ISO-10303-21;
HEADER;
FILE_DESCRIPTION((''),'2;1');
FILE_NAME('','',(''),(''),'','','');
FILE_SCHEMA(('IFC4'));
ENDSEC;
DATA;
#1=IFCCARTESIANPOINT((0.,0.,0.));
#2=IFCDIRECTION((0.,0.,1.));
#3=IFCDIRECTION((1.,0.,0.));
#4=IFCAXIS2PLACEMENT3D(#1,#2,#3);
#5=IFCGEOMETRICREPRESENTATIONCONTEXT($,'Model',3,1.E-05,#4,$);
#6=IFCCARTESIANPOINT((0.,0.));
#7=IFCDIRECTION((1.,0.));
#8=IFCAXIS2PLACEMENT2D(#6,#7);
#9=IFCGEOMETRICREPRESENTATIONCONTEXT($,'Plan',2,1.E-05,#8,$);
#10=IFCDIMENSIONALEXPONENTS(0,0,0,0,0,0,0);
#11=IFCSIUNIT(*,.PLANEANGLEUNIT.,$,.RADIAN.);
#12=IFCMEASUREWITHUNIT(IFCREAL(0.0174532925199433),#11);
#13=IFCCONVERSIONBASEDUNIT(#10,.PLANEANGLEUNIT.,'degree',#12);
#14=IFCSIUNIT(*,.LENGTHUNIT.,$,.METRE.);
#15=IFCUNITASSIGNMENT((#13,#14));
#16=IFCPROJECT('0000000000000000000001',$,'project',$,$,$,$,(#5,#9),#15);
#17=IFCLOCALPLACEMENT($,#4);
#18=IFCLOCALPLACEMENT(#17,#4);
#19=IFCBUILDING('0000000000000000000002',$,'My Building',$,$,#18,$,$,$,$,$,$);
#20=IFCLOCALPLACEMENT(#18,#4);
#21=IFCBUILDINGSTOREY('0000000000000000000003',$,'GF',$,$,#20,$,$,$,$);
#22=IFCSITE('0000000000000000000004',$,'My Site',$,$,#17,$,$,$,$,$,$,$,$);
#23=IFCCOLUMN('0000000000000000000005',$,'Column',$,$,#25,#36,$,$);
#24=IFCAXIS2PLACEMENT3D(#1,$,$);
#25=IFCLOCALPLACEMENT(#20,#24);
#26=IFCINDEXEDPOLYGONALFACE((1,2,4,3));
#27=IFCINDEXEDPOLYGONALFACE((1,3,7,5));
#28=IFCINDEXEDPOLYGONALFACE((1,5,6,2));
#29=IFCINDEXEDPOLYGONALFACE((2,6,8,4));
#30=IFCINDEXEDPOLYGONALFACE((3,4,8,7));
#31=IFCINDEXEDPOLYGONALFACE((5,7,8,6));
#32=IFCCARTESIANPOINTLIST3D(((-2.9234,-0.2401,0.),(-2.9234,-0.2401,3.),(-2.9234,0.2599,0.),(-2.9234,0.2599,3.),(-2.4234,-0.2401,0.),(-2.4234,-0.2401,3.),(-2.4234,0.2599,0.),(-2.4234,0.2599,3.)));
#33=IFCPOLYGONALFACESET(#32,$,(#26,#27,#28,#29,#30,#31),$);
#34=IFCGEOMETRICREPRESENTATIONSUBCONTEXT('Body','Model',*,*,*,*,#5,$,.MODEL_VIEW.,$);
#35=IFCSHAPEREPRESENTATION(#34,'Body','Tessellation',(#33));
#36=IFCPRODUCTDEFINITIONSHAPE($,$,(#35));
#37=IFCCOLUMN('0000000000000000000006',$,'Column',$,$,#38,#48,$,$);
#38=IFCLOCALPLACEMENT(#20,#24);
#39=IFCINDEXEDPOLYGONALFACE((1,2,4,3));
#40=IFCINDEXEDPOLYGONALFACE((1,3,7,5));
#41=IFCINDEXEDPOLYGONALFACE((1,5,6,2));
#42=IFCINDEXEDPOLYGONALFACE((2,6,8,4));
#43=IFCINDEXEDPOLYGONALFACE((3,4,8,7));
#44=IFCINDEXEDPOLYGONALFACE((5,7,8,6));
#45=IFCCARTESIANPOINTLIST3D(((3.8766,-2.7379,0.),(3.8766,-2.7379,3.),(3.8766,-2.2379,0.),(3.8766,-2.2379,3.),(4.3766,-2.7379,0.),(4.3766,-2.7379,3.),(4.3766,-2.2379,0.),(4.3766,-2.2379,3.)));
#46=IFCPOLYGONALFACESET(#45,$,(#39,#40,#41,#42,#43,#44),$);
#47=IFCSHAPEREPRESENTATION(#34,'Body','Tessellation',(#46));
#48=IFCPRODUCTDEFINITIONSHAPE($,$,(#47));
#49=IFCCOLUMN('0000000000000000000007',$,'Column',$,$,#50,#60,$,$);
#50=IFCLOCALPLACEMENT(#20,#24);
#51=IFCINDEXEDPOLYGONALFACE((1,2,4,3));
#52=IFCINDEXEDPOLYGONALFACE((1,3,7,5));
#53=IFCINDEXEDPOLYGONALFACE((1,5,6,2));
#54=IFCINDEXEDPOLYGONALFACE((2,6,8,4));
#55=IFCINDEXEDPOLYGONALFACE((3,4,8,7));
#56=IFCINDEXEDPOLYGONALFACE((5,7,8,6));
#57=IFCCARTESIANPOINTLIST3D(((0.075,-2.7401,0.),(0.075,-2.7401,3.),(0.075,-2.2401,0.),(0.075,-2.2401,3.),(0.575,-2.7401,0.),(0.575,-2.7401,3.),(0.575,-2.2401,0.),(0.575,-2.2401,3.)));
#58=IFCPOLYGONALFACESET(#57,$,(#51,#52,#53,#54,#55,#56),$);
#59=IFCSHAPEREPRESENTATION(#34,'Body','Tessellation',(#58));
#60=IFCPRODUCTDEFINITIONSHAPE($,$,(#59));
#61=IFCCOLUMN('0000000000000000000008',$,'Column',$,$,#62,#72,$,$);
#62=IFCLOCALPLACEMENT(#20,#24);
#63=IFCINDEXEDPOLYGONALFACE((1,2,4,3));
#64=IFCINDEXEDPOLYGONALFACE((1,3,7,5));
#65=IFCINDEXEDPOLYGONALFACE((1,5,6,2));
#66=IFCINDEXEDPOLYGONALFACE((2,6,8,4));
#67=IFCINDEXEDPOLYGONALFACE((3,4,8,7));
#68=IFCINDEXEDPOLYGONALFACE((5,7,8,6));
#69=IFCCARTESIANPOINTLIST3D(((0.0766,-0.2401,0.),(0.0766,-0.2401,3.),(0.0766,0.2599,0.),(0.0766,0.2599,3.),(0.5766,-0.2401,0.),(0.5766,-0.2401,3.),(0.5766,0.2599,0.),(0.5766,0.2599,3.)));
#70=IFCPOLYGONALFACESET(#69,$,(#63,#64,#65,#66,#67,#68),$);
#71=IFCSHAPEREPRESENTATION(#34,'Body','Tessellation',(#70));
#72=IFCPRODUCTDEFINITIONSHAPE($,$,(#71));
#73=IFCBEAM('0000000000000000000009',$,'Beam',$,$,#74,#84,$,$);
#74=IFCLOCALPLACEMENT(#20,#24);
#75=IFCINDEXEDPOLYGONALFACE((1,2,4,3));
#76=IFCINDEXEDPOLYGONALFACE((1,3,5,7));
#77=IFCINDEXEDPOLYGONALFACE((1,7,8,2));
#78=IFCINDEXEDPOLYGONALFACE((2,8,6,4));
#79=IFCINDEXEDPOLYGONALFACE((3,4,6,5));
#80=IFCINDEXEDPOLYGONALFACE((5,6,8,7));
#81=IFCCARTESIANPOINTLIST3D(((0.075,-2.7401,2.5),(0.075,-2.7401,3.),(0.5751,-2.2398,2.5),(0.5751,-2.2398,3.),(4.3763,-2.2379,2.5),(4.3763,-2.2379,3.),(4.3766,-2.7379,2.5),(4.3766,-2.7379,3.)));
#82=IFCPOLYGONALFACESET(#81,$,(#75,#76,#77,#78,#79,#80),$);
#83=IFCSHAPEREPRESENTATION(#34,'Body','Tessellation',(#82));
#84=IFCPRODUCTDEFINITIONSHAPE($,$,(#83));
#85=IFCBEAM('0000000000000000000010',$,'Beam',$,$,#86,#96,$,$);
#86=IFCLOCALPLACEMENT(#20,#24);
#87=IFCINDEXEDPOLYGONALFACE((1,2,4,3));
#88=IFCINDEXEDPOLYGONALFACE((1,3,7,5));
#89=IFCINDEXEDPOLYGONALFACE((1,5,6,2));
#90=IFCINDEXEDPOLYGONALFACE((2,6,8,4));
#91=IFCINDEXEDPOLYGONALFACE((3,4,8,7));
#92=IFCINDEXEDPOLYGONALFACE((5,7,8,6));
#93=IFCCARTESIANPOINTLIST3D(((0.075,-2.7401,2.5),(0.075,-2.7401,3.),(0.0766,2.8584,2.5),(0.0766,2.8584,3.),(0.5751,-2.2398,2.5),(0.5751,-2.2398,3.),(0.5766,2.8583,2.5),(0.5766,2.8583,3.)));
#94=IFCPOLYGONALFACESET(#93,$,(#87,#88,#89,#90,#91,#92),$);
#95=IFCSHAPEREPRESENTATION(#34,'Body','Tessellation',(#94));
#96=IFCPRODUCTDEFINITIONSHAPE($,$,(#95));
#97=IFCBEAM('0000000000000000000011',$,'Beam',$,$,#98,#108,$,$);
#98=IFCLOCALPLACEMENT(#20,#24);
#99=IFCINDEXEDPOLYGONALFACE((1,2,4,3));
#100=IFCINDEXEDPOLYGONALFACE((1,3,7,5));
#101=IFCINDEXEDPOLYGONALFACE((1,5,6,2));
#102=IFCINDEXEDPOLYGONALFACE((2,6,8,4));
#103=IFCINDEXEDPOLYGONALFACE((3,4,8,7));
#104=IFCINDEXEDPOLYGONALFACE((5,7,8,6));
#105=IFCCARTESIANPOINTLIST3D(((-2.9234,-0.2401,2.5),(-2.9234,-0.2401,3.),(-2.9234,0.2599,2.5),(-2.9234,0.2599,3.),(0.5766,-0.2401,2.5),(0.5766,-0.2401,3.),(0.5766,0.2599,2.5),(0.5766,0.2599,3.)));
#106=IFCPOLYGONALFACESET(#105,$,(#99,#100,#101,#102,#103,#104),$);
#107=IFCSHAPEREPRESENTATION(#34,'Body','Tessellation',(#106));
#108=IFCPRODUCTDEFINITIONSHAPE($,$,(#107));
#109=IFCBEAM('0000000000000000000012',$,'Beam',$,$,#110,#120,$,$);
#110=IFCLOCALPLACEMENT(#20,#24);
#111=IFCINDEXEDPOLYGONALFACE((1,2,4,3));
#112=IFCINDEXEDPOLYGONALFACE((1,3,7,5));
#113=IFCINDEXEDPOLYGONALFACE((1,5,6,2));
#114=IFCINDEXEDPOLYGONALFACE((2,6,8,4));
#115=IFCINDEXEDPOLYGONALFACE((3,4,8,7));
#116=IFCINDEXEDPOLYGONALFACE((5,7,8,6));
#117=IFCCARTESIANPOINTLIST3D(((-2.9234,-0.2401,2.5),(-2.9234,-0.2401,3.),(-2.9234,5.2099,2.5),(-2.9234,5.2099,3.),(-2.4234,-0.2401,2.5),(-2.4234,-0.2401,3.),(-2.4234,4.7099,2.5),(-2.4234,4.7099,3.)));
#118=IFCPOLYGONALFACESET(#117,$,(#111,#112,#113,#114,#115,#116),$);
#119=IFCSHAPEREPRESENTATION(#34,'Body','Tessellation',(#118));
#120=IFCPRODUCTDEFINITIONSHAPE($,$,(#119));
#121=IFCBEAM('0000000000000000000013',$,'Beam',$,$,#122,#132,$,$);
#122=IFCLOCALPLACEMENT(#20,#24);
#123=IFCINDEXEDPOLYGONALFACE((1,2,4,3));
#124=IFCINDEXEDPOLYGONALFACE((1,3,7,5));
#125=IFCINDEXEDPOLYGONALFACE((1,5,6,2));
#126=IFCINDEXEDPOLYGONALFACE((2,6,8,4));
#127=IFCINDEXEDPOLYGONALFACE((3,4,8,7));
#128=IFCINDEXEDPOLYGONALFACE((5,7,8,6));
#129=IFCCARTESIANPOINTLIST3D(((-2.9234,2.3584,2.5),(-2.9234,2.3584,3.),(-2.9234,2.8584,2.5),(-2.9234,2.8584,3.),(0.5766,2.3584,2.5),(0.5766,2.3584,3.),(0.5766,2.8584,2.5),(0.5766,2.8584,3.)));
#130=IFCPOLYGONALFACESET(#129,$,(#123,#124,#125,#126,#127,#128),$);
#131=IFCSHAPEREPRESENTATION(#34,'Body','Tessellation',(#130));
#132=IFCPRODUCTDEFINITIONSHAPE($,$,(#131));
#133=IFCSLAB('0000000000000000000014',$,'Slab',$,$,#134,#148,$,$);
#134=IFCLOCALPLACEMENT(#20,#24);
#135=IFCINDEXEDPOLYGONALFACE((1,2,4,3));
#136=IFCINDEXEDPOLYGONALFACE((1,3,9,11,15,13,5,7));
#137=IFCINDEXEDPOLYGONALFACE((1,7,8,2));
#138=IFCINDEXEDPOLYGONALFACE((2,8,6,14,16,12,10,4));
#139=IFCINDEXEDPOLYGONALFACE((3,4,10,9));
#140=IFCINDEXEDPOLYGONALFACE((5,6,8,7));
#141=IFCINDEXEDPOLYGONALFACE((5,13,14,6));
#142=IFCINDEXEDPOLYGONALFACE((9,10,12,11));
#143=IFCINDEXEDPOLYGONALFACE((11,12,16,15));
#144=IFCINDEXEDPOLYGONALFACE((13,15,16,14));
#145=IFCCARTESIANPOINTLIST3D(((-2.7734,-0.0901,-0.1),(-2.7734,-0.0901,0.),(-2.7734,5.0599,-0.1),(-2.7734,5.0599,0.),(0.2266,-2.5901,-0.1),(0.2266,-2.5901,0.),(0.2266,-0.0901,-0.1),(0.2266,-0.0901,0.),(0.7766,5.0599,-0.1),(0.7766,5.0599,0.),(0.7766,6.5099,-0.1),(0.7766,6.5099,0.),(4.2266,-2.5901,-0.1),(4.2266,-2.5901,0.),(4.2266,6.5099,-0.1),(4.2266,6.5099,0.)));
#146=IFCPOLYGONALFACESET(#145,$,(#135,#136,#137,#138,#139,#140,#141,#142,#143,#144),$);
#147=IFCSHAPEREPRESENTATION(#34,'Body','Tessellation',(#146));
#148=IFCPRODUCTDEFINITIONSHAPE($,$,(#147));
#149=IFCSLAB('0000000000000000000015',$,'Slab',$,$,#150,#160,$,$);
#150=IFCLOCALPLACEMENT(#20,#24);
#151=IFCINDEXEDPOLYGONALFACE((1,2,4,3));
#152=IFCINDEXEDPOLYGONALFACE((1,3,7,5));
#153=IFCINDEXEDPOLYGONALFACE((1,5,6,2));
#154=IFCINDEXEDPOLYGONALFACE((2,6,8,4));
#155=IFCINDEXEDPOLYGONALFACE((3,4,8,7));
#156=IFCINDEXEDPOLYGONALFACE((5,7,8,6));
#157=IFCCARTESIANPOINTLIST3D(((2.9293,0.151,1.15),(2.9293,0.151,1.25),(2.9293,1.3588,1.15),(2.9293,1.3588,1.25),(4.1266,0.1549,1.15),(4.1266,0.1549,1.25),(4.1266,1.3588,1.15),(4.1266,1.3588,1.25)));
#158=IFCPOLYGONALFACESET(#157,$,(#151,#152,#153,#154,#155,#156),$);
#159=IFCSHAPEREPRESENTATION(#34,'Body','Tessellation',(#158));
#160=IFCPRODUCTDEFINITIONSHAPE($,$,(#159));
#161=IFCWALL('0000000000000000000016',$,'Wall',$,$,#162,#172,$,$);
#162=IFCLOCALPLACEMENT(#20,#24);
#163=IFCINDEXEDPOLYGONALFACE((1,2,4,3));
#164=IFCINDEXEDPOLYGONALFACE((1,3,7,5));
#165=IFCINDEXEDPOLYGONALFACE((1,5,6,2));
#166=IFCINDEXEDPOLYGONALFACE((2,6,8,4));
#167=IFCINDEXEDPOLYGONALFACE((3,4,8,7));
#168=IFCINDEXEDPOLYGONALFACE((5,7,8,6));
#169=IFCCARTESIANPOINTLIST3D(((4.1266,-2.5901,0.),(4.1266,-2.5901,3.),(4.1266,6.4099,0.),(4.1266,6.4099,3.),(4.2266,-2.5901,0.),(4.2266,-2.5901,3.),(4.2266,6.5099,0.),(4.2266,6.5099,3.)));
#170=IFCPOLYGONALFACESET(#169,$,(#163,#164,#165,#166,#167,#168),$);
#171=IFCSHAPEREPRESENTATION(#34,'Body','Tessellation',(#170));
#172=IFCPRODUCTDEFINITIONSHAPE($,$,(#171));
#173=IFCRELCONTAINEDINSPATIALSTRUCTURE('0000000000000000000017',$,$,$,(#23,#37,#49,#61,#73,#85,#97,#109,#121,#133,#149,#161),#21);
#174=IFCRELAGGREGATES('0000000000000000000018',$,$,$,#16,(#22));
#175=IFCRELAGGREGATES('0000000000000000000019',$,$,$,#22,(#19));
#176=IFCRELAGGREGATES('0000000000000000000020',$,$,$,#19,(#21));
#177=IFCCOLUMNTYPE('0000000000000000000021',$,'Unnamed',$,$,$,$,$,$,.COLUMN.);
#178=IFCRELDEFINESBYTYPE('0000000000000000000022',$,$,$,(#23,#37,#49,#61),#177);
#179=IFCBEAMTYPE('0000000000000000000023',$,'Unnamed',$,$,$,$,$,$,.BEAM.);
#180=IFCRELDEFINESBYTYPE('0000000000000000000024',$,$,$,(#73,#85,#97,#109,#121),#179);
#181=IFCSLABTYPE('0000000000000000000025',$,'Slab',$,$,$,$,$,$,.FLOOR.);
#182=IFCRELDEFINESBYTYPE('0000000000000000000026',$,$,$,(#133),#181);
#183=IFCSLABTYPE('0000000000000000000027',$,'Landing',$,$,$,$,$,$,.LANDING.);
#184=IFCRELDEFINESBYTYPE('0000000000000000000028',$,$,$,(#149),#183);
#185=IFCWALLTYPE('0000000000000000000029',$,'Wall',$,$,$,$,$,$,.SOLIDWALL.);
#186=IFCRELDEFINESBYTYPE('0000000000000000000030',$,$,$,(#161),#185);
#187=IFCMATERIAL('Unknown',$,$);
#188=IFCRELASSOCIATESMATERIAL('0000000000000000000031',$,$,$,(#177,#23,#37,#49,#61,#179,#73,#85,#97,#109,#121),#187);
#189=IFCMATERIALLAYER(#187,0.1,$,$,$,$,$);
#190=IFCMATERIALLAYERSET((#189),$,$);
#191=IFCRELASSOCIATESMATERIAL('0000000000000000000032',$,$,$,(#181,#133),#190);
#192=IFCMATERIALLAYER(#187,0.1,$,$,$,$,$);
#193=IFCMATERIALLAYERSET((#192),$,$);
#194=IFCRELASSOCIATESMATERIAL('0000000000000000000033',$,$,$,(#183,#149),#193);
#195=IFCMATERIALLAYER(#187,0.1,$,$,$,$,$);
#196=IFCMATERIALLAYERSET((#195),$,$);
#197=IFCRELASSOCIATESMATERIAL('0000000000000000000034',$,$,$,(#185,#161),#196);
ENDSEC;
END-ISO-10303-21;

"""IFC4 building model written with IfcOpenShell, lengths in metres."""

from ifc_helpers import new_model, entity, si_unit, converted_unit, frame, origin_with_axes, origin_2d_with_axis, place, context, subcontext, project, spatial, line, indexed_curve, rectangle, outline, extrude, clip, halfspace, material, layer, layer_set, layer_usage, material_profile, profile_set, profile_usage, type_object, element, save


model = new_model("IFC4")

# Units and contexts
model_context = context("Model", 3, precision=1e-05, world=origin_with_axes())
plan_context = context("Plan", 2, precision=1e-05, world=origin_2d_with_axis())
body_context_1 = subcontext(model_context, "Body", "Model", "MODEL_VIEW")
ifc_project = project(units=[converted_unit("PLANEANGLEUNIT", "degree", entity("IfcReal", 0.0174532925199433), si_unit("PLANEANGLEUNIT", "RADIAN"), dimensions=[0, 0, 0, 0, 0, 0, 0]), si_unit("LENGTHUNIT", "METRE")], contexts=[model_context, plan_context])

# Site, building, storey
site_placement = place(None, origin_with_axes())
site = spatial("IfcSite", under=ifc_project, at=site_placement, Name="My Site")
building_placement = place(site_placement, origin_with_axes())
building = spatial("IfcBuilding", under=site, at=building_placement, Name="My Building")
storey_placement = place(building_placement, origin_with_axes())
storey = spatial("IfcBuildingStorey", under=building, at=storey_placement, Name="GF")

# Columns
ifc_material_1 = material(Name="Unknown")
ifc_material_profile_1 = material_profile(ifc_material_1, rectangle(XDim=0.5, YDim=0.5))
ifc_profile_set_1 = profile_set([ifc_material_profile_1])
ifc_profile_usage_1 = profile_usage(ifc_profile_set_1, cardinal=5)
column_type = type_object("IfcColumnType", Name="Unnamed", PredefinedType="COLUMN", material=ifc_profile_set_1)
column_1_placement = place(storey_placement, frame((-2.6734, 0.0099, 0.0), z_axis=(0.0, 0.0, 1.0), x_axis=(1.0, 0.0, 0.0)))
element("IfcColumn", 1, at=column_1_placement, inside=storey, type_object=column_type, material=ifc_profile_usage_1, Name="Column", context=body_context_1, shape_type="SweptSolid", body=[
    extrude(rectangle(XDim=0.5, YDim=0.5), origin_with_axes(), (0.0, 0.0, 1.0), 3.0),
])
ifc_profile_usage_2 = profile_usage(ifc_profile_set_1, cardinal=5)
column_2_placement = place(storey_placement, frame((4.1266, -2.4879, 0.0), z_axis=(0.0, 0.0, 1.0), x_axis=(1.0, 0.0, 0.0)))
element("IfcColumn", 2, at=column_2_placement, inside=storey, type_object=column_type, material=ifc_profile_usage_2, Name="Column", context=body_context_1, shape_type="SweptSolid", body=[
    extrude(rectangle(XDim=0.5, YDim=0.5), origin_with_axes(), (0.0, 0.0, 1.0), 3.0),
])
ifc_profile_usage_3 = profile_usage(ifc_profile_set_1, cardinal=5)
column_3_placement = place(storey_placement, frame((0.325, -2.4901, 0.0), z_axis=(0.0, 0.0, 1.0), x_axis=(1.0, 0.0, 0.0)))
element("IfcColumn", 3, at=column_3_placement, inside=storey, type_object=column_type, material=ifc_profile_usage_3, Name="Column", context=body_context_1, shape_type="SweptSolid", body=[
    extrude(rectangle(XDim=0.5, YDim=0.5), origin_with_axes(), (0.0, 0.0, 1.0), 3.0),
])
ifc_profile_usage_4 = profile_usage(ifc_profile_set_1, cardinal=5)
column_4_placement = place(storey_placement, frame((0.3266, 0.0099, 0.0), z_axis=(0.0, 0.0, 1.0), x_axis=(1.0, 0.0, 0.0)))
element("IfcColumn", 4, at=column_4_placement, inside=storey, type_object=column_type, material=ifc_profile_usage_4, Name="Column", context=body_context_1, shape_type="SweptSolid", body=[
    extrude(rectangle(XDim=0.5, YDim=0.5), origin_with_axes(), (0.0, 0.0, 1.0), 3.0),
])

# Beams
ifc_material_profile_2 = material_profile(ifc_material_1, rectangle(XDim=0.5, YDim=0.5))
ifc_profile_set_2 = profile_set([ifc_material_profile_2])
ifc_profile_usage_5 = profile_usage(ifc_profile_set_2, cardinal=7)
beam_type = type_object("IfcBeamType", Name="Unnamed", PredefinedType="BEAM", material=ifc_profile_set_2)
beam_1_placement = place(storey_placement, frame((4.3766, -2.7379, 3.0), z_axis=(-1.0, -0.000514, 0.0), x_axis=(0.000514, -1.0, 0.0)))
element("IfcBeam", 5, at=beam_1_placement, inside=storey, type_object=beam_type, material=ifc_profile_usage_5, Name="Beam", context=body_context_1, shape_type="Clipping", body=[
    clip(extrude(rectangle(XDim=0.5, YDim=0.5), frame((-0.25, -0.25, 0.0), z_axis=(0.0, 0.0, 1.0), x_axis=(1.0, 0.0, 0.0)), (0.0, 0.0, 1.0), 4.8016), halfspace(frame((0.0, -3.0, 4.3016), z_axis=(-0.707393, 0.0, 0.706821), x_axis=(0.0, 1.0, 0.0)), False)),
])
ifc_profile_usage_6 = profile_usage(ifc_profile_set_2, cardinal=7)
beam_2_placement = place(storey_placement, frame((0.0748, -3.2401, 3.0), z_axis=(0.000293, 1.0, 0.0), x_axis=(-1.0, 0.000293, 0.0)))
element("IfcBeam", 6, at=beam_2_placement, inside=storey, type_object=beam_type, material=ifc_profile_usage_6, Name="Beam", context=body_context_1, shape_type="Clipping", body=[
    clip(extrude(rectangle(XDim=0.5, YDim=0.5), frame((-0.25, -0.25, 0.0), z_axis=(0.0, 0.0, 1.0), x_axis=(1.0, 0.0, 0.0)), (0.0, 0.0, 1.0), 6.0985), halfspace(frame((0.0, -3.0, 0.5), z_axis=(-0.707392, 0.0, -0.706822), x_axis=(0.0, 1.0, 0.0)), False)),
])
ifc_profile_usage_7 = profile_usage(ifc_profile_set_2, cardinal=7)
beam_3_placement = place(storey_placement, frame((0.5766, -0.2401, 3.0), z_axis=(-1.0, 0.0, 0.0), x_axis=(0.0, -1.0, 0.0)))
element("IfcBeam", 7, at=beam_3_placement, inside=storey, type_object=beam_type, material=ifc_profile_usage_7, Name="Beam", context=body_context_1, shape_type="SweptSolid", body=[
    extrude(rectangle(XDim=0.5, YDim=0.5), frame((-0.25, -0.25, 0.0), z_axis=(0.0, 0.0, 1.0), x_axis=(1.0, 0.0, 0.0)), (0.0, 0.0, 1.0), 3.5),
])
ifc_profile_usage_8 = profile_usage(ifc_profile_set_2, cardinal=7)
beam_4_placement = place(storey_placement, frame((-2.9234, -0.2401, 3.0), z_axis=(0.0, 1.0, 0.0), x_axis=(-1.0, 0.0, 0.0)))
element("IfcBeam", 8, at=beam_4_placement, inside=storey, type_object=beam_type, material=ifc_profile_usage_8, Name="Beam", context=body_context_1, shape_type="Clipping", body=[
    clip(extrude(rectangle(XDim=0.5, YDim=0.5), frame((-0.25, -0.25, 0.0), z_axis=(0.0, 0.0, 1.0), x_axis=(1.0, 0.0, 0.0)), (0.0, 0.0, 1.0), 5.45), halfspace(frame((0.0, -3.0, 5.45), z_axis=(-0.707108, 0.0, 0.707106), x_axis=(0.0, 1.0, 0.0)), False)),
])
ifc_profile_usage_9 = profile_usage(ifc_profile_set_2, cardinal=7)
beam_5_placement = place(storey_placement, frame((0.5766, 2.3584, 3.0), z_axis=(-1.0, 0.0, 0.0), x_axis=(0.0, -1.0, 0.0)))
element("IfcBeam", 9, at=beam_5_placement, inside=storey, type_object=beam_type, material=ifc_profile_usage_9, Name="Beam", context=body_context_1, shape_type="SweptSolid", body=[
    extrude(rectangle(XDim=0.5, YDim=0.5), frame((-0.25, -0.25, 0.0), z_axis=(0.0, 0.0, 1.0), x_axis=(1.0, 0.0, 0.0)), (0.0, 0.0, 1.0), 3.5),
])

# Slabs
ifc_layer_1 = layer(ifc_material_1, 0.1)
ifc_layer_set_1 = layer_set([ifc_layer_1])
ifc_layer_usage_1 = layer_usage(ifc_layer_set_1, "AXIS3", "POSITIVE", -0.1)
slab_type_1 = type_object("IfcSlabType", Name="Slab", PredefinedType="FLOOR", material=ifc_layer_set_1)
slab_1_placement = place(storey_placement, frame((4.2266, -2.5901, 0.0), z_axis=(0.0, 0.0, 1.0), x_axis=(1.0, 0.0, 0.0)))
element("IfcSlab", 10, at=slab_1_placement, inside=storey, type_object=slab_type_1, material=ifc_layer_usage_1, Name="Slab", context=body_context_1, shape_type="SweptSolid", body=[
    extrude(outline(indexed_curve([(-4.0, 0.0), (-4.0, 2.5), (-7.0, 2.5), (-7.0, 7.65), (-3.45, 7.65), (-3.45, 9.1), (0.0, 9.1), (0.0, 0.0), (-4.0, 0.0)])), frame((0.0, 0.0, -0.1), z_axis=(0.0, 0.0, 1.0), x_axis=(1.0, 0.0, 0.0)), (0.0, 0.0, 1.0), 0.1),
])
ifc_layer_2 = layer(ifc_material_1, 0.1)
ifc_layer_set_2 = layer_set([ifc_layer_2])
ifc_layer_usage_2 = layer_usage(ifc_layer_set_2, "AXIS3", "POSITIVE", -0.1)
slab_type_2 = type_object("IfcSlabType", Name="Landing", PredefinedType="LANDING", material=ifc_layer_set_2)
slab_2_placement = place(storey_placement, frame((4.1266, 0.1549, 1.25), z_axis=(0.0, 0.0, 1.0), x_axis=(1.0, 0.0, 0.0)))
element("IfcSlab", 11, at=slab_2_placement, inside=storey, type_object=slab_type_2, material=ifc_layer_usage_2, Name="Slab", context=body_context_1, shape_type="SweptSolid", body=[
    extrude(outline(indexed_curve([(0.0, 0.0), (-1.1973, -0.0039), (-1.1973, 1.204), (0.0, 1.204), (0.0, 0.0)])), frame((0.0, 0.0, -0.1), z_axis=(0.0, 0.0, 1.0), x_axis=(1.0, 0.0, 0.0)), (0.0, 0.0, 1.0), 0.1),
])

# Shared definitions
ifc_layer_3 = layer(ifc_material_1, 0.1)
ifc_layer_set_3 = layer_set([ifc_layer_3])
wall_type = type_object("IfcWallType", Name="Wall", PredefinedType="SOLIDWALL", material=ifc_layer_set_3)

# Wall
ifc_layer_usage_3 = layer_usage(ifc_layer_set_3, "AXIS2", "POSITIVE", 0.0)
wall_1_placement = place(storey_placement, frame((4.2266, -2.5901, 0.0), z_axis=(0.0, 0.0, 1.0), x_axis=(0.0, 1.0, 0.0)))
element("IfcWall", 12, at=wall_1_placement, inside=storey, type_object=wall_type, material=ifc_layer_usage_3, Name="Wall", context=body_context_1, shape_type="SweptSolid", body=[
    extrude(outline(indexed_curve([(0.0, 0.0), (0.0, 0.1), (9.0, 0.1), (9.1, 0.0)], segments=[line(1, 2, 3, 4, 1)])), origin_with_axes(), (0.0, 0.0, 1.0), 3.0),
])

save(model, "model.ifc")
